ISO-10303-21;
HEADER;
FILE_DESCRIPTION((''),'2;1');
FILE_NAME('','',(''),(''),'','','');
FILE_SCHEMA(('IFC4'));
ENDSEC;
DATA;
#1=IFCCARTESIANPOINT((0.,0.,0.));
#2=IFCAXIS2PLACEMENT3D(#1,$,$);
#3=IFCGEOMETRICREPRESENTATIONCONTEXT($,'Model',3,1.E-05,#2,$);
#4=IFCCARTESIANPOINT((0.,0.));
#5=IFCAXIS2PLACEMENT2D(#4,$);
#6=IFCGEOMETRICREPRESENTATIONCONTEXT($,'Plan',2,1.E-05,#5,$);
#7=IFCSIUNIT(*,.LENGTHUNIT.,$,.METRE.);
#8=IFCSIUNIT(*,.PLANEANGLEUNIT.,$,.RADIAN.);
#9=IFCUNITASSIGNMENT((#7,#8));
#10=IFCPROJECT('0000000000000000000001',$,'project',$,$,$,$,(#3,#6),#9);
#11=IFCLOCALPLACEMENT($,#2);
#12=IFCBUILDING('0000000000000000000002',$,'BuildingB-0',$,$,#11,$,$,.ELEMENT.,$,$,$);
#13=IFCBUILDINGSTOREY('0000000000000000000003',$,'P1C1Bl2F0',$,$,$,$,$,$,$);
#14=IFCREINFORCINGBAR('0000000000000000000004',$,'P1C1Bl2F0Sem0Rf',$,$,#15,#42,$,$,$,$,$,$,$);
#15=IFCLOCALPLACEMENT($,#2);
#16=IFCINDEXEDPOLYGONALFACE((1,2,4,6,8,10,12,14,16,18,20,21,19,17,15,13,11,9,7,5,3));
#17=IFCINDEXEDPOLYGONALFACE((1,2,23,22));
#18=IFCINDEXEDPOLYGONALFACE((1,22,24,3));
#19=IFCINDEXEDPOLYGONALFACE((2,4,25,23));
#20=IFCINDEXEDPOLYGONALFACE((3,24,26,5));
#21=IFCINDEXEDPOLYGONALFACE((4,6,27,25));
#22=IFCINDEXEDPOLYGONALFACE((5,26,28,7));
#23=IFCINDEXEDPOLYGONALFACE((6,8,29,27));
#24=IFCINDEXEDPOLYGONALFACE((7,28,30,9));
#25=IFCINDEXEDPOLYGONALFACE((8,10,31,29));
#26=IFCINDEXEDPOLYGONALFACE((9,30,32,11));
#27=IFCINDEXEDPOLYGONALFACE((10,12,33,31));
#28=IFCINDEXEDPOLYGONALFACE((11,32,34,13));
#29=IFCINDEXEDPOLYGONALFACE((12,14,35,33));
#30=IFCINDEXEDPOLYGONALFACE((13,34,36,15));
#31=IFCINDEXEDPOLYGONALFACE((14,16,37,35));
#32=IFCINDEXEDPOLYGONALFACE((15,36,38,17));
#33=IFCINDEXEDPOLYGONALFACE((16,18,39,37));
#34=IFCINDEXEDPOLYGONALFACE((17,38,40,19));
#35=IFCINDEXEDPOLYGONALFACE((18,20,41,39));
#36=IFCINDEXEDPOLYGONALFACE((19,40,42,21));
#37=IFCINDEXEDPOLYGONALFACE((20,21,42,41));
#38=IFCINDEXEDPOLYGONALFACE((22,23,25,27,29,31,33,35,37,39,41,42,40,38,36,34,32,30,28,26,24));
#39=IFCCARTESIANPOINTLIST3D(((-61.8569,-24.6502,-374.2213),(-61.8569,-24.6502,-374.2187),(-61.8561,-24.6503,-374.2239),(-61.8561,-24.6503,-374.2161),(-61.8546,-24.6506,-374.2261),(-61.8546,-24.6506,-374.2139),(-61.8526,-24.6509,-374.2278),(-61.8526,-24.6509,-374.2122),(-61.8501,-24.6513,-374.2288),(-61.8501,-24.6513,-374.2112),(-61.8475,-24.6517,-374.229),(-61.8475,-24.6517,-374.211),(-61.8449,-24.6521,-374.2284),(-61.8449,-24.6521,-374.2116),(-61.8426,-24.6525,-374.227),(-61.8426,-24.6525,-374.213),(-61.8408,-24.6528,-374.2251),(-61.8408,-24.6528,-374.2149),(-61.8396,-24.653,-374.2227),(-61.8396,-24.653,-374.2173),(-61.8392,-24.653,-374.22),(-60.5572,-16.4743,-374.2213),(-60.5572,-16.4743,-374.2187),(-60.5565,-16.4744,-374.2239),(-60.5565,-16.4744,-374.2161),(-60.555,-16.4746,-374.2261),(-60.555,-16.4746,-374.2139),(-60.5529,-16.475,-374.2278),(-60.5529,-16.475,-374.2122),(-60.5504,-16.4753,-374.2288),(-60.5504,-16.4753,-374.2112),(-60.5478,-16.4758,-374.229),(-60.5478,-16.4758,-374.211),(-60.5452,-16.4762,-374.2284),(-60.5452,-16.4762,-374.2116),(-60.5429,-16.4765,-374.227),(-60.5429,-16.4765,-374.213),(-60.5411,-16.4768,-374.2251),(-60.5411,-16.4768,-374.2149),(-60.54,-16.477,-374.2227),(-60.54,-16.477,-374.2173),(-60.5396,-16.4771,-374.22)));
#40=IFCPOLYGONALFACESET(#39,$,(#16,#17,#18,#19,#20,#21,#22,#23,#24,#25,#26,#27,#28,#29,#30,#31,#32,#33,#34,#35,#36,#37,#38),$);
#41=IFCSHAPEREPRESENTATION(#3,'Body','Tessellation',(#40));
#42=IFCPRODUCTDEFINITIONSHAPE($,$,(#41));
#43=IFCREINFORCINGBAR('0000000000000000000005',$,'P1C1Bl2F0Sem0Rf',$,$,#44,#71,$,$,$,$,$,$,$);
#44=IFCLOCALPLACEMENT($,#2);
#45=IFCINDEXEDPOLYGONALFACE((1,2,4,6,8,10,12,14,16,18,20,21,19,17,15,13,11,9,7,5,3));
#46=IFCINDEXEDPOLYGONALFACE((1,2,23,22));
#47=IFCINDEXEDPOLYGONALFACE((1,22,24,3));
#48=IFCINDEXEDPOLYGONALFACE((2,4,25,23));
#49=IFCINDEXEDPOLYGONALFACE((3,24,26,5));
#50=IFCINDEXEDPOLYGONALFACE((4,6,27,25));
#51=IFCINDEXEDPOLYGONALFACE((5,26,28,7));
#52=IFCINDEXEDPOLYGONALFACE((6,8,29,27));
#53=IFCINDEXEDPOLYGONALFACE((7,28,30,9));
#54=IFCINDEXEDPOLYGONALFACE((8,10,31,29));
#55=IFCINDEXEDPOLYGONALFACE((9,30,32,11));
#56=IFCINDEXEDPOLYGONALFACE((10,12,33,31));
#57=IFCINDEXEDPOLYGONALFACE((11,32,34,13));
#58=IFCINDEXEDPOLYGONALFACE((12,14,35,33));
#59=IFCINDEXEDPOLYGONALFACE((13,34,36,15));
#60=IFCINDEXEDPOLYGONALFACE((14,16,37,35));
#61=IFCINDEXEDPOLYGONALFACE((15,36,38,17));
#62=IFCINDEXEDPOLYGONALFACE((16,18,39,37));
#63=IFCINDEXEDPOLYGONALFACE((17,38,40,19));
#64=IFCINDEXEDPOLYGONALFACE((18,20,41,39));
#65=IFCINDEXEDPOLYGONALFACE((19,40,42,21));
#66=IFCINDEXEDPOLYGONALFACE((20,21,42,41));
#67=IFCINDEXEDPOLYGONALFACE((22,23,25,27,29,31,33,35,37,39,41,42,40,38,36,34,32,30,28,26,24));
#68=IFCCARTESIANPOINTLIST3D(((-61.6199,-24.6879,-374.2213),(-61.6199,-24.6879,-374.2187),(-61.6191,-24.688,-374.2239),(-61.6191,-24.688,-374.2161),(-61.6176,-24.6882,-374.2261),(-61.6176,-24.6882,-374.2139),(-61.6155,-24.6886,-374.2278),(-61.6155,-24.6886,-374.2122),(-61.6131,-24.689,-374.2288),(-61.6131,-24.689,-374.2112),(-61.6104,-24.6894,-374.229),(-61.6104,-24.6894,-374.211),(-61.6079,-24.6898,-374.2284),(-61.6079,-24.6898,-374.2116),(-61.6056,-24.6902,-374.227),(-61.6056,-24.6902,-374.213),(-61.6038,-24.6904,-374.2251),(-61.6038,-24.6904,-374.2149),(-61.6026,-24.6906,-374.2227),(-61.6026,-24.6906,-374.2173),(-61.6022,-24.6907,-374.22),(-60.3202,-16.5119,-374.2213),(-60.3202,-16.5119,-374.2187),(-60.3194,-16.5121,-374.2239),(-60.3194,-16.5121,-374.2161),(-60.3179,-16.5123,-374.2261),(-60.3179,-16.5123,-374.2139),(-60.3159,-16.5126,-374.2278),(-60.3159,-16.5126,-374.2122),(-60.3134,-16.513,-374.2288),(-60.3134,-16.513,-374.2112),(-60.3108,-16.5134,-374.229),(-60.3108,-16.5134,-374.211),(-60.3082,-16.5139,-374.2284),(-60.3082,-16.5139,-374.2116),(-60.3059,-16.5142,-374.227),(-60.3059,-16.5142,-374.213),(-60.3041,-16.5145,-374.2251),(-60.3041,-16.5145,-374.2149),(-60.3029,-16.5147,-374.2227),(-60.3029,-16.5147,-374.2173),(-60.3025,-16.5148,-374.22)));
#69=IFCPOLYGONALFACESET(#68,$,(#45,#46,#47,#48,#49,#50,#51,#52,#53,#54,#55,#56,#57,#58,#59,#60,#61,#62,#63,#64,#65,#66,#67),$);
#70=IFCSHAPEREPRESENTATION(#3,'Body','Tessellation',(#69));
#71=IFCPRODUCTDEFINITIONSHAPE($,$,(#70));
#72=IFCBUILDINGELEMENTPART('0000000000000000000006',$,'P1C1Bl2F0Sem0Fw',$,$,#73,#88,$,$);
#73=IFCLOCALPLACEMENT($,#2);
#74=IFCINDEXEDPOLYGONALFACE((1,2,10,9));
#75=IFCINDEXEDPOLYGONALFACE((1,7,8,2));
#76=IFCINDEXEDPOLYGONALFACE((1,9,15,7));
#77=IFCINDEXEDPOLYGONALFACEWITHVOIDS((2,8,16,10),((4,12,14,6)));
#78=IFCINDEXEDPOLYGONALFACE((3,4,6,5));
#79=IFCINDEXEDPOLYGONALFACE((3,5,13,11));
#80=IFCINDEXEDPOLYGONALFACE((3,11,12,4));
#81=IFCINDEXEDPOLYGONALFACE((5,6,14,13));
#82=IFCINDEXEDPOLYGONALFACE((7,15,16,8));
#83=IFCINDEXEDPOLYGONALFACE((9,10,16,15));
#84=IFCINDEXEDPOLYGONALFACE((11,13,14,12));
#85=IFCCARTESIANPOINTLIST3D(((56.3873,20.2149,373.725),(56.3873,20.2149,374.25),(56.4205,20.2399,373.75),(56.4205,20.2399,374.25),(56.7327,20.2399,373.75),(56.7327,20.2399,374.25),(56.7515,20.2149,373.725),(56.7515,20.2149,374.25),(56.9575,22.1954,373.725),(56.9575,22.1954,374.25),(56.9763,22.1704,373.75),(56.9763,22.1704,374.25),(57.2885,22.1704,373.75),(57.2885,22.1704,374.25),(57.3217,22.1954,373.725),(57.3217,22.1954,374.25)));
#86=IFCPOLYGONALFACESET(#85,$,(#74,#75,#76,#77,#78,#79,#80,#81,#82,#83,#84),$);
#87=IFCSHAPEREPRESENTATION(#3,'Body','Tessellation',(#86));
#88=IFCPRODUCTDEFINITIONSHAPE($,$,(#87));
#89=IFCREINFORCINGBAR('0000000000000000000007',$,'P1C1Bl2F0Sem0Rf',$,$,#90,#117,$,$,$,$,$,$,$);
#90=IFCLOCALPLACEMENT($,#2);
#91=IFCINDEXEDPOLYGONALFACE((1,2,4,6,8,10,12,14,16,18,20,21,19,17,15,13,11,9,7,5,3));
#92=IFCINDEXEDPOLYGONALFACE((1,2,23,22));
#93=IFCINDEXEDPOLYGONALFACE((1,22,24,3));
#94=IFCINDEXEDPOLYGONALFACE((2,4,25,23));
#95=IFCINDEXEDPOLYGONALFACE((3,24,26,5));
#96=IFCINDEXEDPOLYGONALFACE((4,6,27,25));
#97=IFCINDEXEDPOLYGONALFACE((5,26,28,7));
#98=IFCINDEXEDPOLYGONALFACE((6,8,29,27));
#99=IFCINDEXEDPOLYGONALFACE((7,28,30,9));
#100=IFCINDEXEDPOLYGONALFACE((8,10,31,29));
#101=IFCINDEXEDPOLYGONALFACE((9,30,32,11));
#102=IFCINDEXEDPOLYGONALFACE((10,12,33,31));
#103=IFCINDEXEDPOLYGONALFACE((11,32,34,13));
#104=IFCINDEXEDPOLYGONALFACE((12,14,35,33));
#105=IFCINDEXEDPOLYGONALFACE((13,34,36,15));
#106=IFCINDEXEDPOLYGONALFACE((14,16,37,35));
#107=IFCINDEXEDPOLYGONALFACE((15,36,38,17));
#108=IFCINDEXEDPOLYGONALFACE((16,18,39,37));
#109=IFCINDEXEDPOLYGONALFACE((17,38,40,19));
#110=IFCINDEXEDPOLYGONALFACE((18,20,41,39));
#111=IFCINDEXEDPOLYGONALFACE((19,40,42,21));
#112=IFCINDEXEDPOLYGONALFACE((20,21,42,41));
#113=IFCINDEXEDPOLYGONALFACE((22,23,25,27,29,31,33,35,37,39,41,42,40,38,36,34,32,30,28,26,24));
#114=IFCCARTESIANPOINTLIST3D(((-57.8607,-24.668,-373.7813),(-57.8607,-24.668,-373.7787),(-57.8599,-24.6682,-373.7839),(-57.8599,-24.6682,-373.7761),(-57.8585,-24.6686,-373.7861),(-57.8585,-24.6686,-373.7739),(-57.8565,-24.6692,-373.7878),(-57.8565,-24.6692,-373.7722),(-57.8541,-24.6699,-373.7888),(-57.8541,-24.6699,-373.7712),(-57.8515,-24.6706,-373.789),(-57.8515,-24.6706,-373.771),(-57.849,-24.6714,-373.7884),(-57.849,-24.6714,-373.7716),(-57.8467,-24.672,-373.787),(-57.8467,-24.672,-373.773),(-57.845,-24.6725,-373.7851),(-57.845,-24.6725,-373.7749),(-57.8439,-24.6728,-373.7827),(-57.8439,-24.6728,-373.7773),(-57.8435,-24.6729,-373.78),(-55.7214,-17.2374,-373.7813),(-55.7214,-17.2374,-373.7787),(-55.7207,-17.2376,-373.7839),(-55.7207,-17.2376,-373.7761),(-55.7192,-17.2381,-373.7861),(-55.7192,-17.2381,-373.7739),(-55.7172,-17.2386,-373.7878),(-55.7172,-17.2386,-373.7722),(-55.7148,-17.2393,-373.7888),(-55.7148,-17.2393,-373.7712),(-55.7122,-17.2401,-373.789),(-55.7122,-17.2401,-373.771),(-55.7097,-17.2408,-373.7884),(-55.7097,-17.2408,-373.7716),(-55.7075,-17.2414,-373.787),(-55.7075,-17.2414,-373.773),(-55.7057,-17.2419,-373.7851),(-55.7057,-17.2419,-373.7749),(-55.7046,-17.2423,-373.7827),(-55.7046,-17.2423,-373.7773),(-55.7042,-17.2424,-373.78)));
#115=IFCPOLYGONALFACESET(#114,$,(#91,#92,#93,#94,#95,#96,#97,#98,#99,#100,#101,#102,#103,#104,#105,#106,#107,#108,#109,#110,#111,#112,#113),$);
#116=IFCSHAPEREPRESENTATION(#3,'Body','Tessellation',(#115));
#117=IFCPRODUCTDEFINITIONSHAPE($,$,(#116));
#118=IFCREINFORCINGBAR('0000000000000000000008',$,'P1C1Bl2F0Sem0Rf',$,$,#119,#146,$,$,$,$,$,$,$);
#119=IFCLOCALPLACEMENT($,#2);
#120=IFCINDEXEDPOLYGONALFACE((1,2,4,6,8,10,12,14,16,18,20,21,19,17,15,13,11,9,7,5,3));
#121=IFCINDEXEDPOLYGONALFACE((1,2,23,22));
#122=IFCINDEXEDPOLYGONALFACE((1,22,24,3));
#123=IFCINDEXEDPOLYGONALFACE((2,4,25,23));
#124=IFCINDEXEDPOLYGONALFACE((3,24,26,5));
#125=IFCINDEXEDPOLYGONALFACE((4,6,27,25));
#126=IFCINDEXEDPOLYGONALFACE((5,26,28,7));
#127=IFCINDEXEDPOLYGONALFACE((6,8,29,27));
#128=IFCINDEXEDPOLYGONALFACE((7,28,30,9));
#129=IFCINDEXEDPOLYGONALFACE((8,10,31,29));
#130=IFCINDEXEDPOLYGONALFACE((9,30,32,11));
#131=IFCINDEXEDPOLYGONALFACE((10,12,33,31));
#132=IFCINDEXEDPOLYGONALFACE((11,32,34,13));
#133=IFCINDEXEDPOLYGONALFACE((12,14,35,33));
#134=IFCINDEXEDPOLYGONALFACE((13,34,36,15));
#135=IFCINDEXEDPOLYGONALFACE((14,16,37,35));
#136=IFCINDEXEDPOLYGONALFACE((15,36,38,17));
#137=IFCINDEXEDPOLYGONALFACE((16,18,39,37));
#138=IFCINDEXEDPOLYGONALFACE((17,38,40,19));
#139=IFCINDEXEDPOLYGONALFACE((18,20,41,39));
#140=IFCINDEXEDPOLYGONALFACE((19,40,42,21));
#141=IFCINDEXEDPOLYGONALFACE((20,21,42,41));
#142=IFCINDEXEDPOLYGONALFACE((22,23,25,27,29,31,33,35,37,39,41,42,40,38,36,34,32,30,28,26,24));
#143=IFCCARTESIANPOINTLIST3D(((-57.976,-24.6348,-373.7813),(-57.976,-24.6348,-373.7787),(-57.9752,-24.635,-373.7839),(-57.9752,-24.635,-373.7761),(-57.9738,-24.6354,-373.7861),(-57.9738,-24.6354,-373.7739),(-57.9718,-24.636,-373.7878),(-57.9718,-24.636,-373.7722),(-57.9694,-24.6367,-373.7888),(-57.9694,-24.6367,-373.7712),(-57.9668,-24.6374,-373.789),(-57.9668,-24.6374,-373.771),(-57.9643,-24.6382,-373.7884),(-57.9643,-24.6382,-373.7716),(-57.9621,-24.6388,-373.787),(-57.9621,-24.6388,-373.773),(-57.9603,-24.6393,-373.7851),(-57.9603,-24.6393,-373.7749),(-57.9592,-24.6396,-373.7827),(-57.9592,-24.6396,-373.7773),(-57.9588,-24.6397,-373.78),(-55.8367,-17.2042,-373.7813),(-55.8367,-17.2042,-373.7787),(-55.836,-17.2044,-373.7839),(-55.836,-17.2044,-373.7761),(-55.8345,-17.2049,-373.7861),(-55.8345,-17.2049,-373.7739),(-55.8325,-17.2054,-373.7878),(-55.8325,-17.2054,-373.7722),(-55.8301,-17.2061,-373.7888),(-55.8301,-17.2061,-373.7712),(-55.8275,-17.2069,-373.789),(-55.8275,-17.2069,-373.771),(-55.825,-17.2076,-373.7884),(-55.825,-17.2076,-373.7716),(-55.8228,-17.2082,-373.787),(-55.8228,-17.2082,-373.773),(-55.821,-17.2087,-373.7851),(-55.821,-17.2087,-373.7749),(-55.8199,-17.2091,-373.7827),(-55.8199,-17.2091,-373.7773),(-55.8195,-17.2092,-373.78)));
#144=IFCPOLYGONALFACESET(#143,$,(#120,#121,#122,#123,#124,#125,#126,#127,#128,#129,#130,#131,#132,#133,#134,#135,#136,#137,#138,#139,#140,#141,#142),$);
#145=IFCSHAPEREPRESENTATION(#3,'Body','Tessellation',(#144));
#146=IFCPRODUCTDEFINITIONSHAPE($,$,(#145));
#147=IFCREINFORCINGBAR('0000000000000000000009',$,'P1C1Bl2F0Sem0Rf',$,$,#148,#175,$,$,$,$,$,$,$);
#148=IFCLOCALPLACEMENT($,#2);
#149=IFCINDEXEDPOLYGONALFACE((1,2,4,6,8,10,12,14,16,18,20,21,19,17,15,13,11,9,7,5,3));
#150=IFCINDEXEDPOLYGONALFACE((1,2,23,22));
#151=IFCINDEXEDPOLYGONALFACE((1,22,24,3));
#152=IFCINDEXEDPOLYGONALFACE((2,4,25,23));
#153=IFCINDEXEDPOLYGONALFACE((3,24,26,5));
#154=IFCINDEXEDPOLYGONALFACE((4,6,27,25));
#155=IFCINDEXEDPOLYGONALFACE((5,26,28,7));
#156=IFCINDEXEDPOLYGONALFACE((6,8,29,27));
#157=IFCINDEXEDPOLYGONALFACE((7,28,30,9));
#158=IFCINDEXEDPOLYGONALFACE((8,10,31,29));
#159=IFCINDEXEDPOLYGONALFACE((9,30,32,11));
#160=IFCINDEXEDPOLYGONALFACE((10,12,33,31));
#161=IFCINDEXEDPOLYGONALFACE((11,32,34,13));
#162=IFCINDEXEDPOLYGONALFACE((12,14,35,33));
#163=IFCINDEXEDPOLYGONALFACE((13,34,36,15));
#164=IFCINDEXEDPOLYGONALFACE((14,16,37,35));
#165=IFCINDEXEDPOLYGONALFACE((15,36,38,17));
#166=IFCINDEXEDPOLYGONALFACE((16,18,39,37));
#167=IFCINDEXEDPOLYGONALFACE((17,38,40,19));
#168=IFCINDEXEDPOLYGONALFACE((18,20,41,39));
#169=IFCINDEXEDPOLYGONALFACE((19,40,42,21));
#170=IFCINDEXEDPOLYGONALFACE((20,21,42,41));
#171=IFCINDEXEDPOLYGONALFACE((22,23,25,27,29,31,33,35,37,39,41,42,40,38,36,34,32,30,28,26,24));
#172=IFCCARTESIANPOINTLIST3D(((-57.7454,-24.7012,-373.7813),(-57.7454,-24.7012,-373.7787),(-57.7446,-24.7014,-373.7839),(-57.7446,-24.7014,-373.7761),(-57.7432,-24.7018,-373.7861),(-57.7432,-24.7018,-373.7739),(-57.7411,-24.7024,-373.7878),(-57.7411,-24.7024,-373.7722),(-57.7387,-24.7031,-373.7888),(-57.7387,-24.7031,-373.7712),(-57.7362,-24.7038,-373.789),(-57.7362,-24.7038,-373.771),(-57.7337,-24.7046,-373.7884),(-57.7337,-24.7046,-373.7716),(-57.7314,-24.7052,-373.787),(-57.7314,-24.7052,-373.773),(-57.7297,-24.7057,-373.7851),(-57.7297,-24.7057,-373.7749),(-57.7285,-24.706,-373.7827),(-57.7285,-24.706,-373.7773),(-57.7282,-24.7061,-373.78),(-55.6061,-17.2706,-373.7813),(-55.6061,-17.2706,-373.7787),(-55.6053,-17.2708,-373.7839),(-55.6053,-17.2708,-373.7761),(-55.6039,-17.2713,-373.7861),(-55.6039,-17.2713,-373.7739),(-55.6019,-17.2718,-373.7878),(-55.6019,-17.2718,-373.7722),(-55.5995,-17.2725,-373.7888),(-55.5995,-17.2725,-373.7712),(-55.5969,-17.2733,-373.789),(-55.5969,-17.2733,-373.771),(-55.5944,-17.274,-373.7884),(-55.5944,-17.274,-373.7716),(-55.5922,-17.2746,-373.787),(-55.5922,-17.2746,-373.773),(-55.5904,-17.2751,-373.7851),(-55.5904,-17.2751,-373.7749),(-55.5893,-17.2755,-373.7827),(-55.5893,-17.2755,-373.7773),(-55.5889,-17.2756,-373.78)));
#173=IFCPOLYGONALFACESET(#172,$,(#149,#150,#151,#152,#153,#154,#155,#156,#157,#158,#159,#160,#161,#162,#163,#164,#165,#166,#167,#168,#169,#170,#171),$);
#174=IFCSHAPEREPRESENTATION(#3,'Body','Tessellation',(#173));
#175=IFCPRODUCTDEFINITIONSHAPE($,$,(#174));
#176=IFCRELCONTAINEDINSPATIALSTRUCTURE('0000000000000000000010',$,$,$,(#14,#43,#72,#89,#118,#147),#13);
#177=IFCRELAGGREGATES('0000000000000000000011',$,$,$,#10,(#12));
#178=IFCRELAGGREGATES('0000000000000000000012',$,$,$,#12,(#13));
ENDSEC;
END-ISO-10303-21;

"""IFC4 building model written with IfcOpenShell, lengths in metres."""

from ifc_helpers import new_model, entity, si_unit, origin, origin_2d, place, context, project, spatial, polyline, outline, extrude, element, save


model = new_model("IFC4")

# Units and contexts
model_context = context("Model", 3, precision=1e-05, world=origin())
plan_context = context("Plan", 2, precision=1e-05, world=origin_2d())
ifc_project = project(units=[si_unit("LENGTHUNIT", "METRE"), si_unit("PLANEANGLEUNIT", "RADIAN")], contexts=[model_context, plan_context])

# Building, storey
building_placement = place(None, origin())
building = spatial("IfcBuilding", under=ifc_project, at=building_placement, Name="BuildingB-0", CompositionType="ELEMENT")
storey = spatial("IfcBuildingStorey", under=building, Name="P1C1Bl2F0")

# Reinforcing bars
element("IfcReinforcingBar", 1, inside=storey, Name="P1C1Bl2F0Sem0Rf", context=model_context, shape_type="SweptSolid", body=[
    entity("IfcSurfaceCurveSweptAreaSolid", entity("IfcCircleProfileDef", "AREA", None, None, 0.009), None, entity("IfcPolyline", [entity("IfcCartesianPoint", [60.5484, 16.4757, 374.22]), entity("IfcCartesianPoint", [61.8481, 24.6516, 374.22])]), None, None, entity("IfcPlane", entity("IfcAxis2Placement3D", entity("IfcCartesianPoint", [60.5484, 16.4757, 374.22]), entity("IfcDirection", [0.0, 0.0, 1.0]), entity("IfcDirection", [1.0, 0.0, 0.0])))),
])
element("IfcReinforcingBar", 2, inside=storey, Name="P1C1Bl2F0Sem0Rf", context=model_context, shape_type="SweptSolid", body=[
    entity("IfcSurfaceCurveSweptAreaSolid", entity("IfcCircleProfileDef", "AREA", None, None, 0.009), None, entity("IfcPolyline", [entity("IfcCartesianPoint", [60.3114, 16.5133, 374.22]), entity("IfcCartesianPoint", [61.6111, 24.6893, 374.22])]), None, None, entity("IfcPlane", entity("IfcAxis2Placement3D", entity("IfcCartesianPoint", [60.3114, 16.5133, 374.22]), entity("IfcDirection", [0.0, 0.0, 1.0]), entity("IfcDirection", [1.0, 0.0, 0.0])))),
])

# Building element part, opening
building_element_part_1 = element("IfcBuildingElementPart", 3, inside=storey, Name="P1C1Bl2F0Sem0Fw", context=model_context, shape_type="SweptSolid", body=[
    extrude(outline(polyline([(56.7515, 20.2149, 373.725), (56.3873, 20.2149, 373.725), (56.9575, 22.1954, 373.725), (57.3217, 22.1954, 373.725), (56.7515, 20.2149, 373.725)])), None, (0.0, 0.0, 1.0), 0.525),
])
element("IfcOpeningElement", 4, inside=storey, cuts=building_element_part_1, context=model_context, shape_type="SweptSolid", body=[
    extrude(outline(polyline([(56.7327, 20.2399, 373.75), (56.4205, 20.2399, 373.75), (56.9763, 22.1704, 373.75), (57.2885, 22.1704, 373.75), (56.7327, 20.2399, 373.75)])), None, (0.0, 0.0, 1.0), 0.5),
])

# Reinforcing bars
element("IfcReinforcingBar", 5, inside=storey, Name="P1C1Bl2F0Sem0Rf", context=model_context, shape_type="SweptSolid", body=[
    entity("IfcSurfaceCurveSweptAreaSolid", entity("IfcCircleProfileDef", "AREA", None, None, 0.009), None, entity("IfcPolyline", [entity("IfcCartesianPoint", [55.7129, 17.2399, 373.78]), entity("IfcCartesianPoint", [57.8521, 24.6704, 373.78])]), None, None, entity("IfcPlane", entity("IfcAxis2Placement3D", entity("IfcCartesianPoint", [55.7129, 17.2399, 373.78]), entity("IfcDirection", [0.0, 0.0, 1.0]), entity("IfcDirection", [1.0, 0.0, 0.0])))),
])
element("IfcReinforcingBar", 6, inside=storey, Name="P1C1Bl2F0Sem0Rf", context=model_context, shape_type="SweptSolid", body=[
    entity("IfcSurfaceCurveSweptAreaSolid", entity("IfcCircleProfileDef", "AREA", None, None, 0.009), None, entity("IfcPolyline", [entity("IfcCartesianPoint", [55.8282, 17.2067, 373.78]), entity("IfcCartesianPoint", [57.9674, 24.6372, 373.78])]), None, None, entity("IfcPlane", entity("IfcAxis2Placement3D", entity("IfcCartesianPoint", [55.8282, 17.2067, 373.78]), entity("IfcDirection", [0.0, 0.0, 1.0]), entity("IfcDirection", [1.0, 0.0, 0.0])))),
])
element("IfcReinforcingBar", 7, inside=storey, Name="P1C1Bl2F0Sem0Rf", context=model_context, shape_type="SweptSolid", body=[
    entity("IfcSurfaceCurveSweptAreaSolid", entity("IfcCircleProfileDef", "AREA", None, None, 0.009), None, entity("IfcPolyline", [entity("IfcCartesianPoint", [55.5975, 17.2731, 373.78]), entity("IfcCartesianPoint", [57.7368, 24.7036, 373.78])]), None, None, entity("IfcPlane", entity("IfcAxis2Placement3D", entity("IfcCartesianPoint", [55.5975, 17.2731, 373.78]), entity("IfcDirection", [0.0, 0.0, 1.0]), entity("IfcDirection", [1.0, 0.0, 0.0])))),
])

save(model, "model.ifc")
